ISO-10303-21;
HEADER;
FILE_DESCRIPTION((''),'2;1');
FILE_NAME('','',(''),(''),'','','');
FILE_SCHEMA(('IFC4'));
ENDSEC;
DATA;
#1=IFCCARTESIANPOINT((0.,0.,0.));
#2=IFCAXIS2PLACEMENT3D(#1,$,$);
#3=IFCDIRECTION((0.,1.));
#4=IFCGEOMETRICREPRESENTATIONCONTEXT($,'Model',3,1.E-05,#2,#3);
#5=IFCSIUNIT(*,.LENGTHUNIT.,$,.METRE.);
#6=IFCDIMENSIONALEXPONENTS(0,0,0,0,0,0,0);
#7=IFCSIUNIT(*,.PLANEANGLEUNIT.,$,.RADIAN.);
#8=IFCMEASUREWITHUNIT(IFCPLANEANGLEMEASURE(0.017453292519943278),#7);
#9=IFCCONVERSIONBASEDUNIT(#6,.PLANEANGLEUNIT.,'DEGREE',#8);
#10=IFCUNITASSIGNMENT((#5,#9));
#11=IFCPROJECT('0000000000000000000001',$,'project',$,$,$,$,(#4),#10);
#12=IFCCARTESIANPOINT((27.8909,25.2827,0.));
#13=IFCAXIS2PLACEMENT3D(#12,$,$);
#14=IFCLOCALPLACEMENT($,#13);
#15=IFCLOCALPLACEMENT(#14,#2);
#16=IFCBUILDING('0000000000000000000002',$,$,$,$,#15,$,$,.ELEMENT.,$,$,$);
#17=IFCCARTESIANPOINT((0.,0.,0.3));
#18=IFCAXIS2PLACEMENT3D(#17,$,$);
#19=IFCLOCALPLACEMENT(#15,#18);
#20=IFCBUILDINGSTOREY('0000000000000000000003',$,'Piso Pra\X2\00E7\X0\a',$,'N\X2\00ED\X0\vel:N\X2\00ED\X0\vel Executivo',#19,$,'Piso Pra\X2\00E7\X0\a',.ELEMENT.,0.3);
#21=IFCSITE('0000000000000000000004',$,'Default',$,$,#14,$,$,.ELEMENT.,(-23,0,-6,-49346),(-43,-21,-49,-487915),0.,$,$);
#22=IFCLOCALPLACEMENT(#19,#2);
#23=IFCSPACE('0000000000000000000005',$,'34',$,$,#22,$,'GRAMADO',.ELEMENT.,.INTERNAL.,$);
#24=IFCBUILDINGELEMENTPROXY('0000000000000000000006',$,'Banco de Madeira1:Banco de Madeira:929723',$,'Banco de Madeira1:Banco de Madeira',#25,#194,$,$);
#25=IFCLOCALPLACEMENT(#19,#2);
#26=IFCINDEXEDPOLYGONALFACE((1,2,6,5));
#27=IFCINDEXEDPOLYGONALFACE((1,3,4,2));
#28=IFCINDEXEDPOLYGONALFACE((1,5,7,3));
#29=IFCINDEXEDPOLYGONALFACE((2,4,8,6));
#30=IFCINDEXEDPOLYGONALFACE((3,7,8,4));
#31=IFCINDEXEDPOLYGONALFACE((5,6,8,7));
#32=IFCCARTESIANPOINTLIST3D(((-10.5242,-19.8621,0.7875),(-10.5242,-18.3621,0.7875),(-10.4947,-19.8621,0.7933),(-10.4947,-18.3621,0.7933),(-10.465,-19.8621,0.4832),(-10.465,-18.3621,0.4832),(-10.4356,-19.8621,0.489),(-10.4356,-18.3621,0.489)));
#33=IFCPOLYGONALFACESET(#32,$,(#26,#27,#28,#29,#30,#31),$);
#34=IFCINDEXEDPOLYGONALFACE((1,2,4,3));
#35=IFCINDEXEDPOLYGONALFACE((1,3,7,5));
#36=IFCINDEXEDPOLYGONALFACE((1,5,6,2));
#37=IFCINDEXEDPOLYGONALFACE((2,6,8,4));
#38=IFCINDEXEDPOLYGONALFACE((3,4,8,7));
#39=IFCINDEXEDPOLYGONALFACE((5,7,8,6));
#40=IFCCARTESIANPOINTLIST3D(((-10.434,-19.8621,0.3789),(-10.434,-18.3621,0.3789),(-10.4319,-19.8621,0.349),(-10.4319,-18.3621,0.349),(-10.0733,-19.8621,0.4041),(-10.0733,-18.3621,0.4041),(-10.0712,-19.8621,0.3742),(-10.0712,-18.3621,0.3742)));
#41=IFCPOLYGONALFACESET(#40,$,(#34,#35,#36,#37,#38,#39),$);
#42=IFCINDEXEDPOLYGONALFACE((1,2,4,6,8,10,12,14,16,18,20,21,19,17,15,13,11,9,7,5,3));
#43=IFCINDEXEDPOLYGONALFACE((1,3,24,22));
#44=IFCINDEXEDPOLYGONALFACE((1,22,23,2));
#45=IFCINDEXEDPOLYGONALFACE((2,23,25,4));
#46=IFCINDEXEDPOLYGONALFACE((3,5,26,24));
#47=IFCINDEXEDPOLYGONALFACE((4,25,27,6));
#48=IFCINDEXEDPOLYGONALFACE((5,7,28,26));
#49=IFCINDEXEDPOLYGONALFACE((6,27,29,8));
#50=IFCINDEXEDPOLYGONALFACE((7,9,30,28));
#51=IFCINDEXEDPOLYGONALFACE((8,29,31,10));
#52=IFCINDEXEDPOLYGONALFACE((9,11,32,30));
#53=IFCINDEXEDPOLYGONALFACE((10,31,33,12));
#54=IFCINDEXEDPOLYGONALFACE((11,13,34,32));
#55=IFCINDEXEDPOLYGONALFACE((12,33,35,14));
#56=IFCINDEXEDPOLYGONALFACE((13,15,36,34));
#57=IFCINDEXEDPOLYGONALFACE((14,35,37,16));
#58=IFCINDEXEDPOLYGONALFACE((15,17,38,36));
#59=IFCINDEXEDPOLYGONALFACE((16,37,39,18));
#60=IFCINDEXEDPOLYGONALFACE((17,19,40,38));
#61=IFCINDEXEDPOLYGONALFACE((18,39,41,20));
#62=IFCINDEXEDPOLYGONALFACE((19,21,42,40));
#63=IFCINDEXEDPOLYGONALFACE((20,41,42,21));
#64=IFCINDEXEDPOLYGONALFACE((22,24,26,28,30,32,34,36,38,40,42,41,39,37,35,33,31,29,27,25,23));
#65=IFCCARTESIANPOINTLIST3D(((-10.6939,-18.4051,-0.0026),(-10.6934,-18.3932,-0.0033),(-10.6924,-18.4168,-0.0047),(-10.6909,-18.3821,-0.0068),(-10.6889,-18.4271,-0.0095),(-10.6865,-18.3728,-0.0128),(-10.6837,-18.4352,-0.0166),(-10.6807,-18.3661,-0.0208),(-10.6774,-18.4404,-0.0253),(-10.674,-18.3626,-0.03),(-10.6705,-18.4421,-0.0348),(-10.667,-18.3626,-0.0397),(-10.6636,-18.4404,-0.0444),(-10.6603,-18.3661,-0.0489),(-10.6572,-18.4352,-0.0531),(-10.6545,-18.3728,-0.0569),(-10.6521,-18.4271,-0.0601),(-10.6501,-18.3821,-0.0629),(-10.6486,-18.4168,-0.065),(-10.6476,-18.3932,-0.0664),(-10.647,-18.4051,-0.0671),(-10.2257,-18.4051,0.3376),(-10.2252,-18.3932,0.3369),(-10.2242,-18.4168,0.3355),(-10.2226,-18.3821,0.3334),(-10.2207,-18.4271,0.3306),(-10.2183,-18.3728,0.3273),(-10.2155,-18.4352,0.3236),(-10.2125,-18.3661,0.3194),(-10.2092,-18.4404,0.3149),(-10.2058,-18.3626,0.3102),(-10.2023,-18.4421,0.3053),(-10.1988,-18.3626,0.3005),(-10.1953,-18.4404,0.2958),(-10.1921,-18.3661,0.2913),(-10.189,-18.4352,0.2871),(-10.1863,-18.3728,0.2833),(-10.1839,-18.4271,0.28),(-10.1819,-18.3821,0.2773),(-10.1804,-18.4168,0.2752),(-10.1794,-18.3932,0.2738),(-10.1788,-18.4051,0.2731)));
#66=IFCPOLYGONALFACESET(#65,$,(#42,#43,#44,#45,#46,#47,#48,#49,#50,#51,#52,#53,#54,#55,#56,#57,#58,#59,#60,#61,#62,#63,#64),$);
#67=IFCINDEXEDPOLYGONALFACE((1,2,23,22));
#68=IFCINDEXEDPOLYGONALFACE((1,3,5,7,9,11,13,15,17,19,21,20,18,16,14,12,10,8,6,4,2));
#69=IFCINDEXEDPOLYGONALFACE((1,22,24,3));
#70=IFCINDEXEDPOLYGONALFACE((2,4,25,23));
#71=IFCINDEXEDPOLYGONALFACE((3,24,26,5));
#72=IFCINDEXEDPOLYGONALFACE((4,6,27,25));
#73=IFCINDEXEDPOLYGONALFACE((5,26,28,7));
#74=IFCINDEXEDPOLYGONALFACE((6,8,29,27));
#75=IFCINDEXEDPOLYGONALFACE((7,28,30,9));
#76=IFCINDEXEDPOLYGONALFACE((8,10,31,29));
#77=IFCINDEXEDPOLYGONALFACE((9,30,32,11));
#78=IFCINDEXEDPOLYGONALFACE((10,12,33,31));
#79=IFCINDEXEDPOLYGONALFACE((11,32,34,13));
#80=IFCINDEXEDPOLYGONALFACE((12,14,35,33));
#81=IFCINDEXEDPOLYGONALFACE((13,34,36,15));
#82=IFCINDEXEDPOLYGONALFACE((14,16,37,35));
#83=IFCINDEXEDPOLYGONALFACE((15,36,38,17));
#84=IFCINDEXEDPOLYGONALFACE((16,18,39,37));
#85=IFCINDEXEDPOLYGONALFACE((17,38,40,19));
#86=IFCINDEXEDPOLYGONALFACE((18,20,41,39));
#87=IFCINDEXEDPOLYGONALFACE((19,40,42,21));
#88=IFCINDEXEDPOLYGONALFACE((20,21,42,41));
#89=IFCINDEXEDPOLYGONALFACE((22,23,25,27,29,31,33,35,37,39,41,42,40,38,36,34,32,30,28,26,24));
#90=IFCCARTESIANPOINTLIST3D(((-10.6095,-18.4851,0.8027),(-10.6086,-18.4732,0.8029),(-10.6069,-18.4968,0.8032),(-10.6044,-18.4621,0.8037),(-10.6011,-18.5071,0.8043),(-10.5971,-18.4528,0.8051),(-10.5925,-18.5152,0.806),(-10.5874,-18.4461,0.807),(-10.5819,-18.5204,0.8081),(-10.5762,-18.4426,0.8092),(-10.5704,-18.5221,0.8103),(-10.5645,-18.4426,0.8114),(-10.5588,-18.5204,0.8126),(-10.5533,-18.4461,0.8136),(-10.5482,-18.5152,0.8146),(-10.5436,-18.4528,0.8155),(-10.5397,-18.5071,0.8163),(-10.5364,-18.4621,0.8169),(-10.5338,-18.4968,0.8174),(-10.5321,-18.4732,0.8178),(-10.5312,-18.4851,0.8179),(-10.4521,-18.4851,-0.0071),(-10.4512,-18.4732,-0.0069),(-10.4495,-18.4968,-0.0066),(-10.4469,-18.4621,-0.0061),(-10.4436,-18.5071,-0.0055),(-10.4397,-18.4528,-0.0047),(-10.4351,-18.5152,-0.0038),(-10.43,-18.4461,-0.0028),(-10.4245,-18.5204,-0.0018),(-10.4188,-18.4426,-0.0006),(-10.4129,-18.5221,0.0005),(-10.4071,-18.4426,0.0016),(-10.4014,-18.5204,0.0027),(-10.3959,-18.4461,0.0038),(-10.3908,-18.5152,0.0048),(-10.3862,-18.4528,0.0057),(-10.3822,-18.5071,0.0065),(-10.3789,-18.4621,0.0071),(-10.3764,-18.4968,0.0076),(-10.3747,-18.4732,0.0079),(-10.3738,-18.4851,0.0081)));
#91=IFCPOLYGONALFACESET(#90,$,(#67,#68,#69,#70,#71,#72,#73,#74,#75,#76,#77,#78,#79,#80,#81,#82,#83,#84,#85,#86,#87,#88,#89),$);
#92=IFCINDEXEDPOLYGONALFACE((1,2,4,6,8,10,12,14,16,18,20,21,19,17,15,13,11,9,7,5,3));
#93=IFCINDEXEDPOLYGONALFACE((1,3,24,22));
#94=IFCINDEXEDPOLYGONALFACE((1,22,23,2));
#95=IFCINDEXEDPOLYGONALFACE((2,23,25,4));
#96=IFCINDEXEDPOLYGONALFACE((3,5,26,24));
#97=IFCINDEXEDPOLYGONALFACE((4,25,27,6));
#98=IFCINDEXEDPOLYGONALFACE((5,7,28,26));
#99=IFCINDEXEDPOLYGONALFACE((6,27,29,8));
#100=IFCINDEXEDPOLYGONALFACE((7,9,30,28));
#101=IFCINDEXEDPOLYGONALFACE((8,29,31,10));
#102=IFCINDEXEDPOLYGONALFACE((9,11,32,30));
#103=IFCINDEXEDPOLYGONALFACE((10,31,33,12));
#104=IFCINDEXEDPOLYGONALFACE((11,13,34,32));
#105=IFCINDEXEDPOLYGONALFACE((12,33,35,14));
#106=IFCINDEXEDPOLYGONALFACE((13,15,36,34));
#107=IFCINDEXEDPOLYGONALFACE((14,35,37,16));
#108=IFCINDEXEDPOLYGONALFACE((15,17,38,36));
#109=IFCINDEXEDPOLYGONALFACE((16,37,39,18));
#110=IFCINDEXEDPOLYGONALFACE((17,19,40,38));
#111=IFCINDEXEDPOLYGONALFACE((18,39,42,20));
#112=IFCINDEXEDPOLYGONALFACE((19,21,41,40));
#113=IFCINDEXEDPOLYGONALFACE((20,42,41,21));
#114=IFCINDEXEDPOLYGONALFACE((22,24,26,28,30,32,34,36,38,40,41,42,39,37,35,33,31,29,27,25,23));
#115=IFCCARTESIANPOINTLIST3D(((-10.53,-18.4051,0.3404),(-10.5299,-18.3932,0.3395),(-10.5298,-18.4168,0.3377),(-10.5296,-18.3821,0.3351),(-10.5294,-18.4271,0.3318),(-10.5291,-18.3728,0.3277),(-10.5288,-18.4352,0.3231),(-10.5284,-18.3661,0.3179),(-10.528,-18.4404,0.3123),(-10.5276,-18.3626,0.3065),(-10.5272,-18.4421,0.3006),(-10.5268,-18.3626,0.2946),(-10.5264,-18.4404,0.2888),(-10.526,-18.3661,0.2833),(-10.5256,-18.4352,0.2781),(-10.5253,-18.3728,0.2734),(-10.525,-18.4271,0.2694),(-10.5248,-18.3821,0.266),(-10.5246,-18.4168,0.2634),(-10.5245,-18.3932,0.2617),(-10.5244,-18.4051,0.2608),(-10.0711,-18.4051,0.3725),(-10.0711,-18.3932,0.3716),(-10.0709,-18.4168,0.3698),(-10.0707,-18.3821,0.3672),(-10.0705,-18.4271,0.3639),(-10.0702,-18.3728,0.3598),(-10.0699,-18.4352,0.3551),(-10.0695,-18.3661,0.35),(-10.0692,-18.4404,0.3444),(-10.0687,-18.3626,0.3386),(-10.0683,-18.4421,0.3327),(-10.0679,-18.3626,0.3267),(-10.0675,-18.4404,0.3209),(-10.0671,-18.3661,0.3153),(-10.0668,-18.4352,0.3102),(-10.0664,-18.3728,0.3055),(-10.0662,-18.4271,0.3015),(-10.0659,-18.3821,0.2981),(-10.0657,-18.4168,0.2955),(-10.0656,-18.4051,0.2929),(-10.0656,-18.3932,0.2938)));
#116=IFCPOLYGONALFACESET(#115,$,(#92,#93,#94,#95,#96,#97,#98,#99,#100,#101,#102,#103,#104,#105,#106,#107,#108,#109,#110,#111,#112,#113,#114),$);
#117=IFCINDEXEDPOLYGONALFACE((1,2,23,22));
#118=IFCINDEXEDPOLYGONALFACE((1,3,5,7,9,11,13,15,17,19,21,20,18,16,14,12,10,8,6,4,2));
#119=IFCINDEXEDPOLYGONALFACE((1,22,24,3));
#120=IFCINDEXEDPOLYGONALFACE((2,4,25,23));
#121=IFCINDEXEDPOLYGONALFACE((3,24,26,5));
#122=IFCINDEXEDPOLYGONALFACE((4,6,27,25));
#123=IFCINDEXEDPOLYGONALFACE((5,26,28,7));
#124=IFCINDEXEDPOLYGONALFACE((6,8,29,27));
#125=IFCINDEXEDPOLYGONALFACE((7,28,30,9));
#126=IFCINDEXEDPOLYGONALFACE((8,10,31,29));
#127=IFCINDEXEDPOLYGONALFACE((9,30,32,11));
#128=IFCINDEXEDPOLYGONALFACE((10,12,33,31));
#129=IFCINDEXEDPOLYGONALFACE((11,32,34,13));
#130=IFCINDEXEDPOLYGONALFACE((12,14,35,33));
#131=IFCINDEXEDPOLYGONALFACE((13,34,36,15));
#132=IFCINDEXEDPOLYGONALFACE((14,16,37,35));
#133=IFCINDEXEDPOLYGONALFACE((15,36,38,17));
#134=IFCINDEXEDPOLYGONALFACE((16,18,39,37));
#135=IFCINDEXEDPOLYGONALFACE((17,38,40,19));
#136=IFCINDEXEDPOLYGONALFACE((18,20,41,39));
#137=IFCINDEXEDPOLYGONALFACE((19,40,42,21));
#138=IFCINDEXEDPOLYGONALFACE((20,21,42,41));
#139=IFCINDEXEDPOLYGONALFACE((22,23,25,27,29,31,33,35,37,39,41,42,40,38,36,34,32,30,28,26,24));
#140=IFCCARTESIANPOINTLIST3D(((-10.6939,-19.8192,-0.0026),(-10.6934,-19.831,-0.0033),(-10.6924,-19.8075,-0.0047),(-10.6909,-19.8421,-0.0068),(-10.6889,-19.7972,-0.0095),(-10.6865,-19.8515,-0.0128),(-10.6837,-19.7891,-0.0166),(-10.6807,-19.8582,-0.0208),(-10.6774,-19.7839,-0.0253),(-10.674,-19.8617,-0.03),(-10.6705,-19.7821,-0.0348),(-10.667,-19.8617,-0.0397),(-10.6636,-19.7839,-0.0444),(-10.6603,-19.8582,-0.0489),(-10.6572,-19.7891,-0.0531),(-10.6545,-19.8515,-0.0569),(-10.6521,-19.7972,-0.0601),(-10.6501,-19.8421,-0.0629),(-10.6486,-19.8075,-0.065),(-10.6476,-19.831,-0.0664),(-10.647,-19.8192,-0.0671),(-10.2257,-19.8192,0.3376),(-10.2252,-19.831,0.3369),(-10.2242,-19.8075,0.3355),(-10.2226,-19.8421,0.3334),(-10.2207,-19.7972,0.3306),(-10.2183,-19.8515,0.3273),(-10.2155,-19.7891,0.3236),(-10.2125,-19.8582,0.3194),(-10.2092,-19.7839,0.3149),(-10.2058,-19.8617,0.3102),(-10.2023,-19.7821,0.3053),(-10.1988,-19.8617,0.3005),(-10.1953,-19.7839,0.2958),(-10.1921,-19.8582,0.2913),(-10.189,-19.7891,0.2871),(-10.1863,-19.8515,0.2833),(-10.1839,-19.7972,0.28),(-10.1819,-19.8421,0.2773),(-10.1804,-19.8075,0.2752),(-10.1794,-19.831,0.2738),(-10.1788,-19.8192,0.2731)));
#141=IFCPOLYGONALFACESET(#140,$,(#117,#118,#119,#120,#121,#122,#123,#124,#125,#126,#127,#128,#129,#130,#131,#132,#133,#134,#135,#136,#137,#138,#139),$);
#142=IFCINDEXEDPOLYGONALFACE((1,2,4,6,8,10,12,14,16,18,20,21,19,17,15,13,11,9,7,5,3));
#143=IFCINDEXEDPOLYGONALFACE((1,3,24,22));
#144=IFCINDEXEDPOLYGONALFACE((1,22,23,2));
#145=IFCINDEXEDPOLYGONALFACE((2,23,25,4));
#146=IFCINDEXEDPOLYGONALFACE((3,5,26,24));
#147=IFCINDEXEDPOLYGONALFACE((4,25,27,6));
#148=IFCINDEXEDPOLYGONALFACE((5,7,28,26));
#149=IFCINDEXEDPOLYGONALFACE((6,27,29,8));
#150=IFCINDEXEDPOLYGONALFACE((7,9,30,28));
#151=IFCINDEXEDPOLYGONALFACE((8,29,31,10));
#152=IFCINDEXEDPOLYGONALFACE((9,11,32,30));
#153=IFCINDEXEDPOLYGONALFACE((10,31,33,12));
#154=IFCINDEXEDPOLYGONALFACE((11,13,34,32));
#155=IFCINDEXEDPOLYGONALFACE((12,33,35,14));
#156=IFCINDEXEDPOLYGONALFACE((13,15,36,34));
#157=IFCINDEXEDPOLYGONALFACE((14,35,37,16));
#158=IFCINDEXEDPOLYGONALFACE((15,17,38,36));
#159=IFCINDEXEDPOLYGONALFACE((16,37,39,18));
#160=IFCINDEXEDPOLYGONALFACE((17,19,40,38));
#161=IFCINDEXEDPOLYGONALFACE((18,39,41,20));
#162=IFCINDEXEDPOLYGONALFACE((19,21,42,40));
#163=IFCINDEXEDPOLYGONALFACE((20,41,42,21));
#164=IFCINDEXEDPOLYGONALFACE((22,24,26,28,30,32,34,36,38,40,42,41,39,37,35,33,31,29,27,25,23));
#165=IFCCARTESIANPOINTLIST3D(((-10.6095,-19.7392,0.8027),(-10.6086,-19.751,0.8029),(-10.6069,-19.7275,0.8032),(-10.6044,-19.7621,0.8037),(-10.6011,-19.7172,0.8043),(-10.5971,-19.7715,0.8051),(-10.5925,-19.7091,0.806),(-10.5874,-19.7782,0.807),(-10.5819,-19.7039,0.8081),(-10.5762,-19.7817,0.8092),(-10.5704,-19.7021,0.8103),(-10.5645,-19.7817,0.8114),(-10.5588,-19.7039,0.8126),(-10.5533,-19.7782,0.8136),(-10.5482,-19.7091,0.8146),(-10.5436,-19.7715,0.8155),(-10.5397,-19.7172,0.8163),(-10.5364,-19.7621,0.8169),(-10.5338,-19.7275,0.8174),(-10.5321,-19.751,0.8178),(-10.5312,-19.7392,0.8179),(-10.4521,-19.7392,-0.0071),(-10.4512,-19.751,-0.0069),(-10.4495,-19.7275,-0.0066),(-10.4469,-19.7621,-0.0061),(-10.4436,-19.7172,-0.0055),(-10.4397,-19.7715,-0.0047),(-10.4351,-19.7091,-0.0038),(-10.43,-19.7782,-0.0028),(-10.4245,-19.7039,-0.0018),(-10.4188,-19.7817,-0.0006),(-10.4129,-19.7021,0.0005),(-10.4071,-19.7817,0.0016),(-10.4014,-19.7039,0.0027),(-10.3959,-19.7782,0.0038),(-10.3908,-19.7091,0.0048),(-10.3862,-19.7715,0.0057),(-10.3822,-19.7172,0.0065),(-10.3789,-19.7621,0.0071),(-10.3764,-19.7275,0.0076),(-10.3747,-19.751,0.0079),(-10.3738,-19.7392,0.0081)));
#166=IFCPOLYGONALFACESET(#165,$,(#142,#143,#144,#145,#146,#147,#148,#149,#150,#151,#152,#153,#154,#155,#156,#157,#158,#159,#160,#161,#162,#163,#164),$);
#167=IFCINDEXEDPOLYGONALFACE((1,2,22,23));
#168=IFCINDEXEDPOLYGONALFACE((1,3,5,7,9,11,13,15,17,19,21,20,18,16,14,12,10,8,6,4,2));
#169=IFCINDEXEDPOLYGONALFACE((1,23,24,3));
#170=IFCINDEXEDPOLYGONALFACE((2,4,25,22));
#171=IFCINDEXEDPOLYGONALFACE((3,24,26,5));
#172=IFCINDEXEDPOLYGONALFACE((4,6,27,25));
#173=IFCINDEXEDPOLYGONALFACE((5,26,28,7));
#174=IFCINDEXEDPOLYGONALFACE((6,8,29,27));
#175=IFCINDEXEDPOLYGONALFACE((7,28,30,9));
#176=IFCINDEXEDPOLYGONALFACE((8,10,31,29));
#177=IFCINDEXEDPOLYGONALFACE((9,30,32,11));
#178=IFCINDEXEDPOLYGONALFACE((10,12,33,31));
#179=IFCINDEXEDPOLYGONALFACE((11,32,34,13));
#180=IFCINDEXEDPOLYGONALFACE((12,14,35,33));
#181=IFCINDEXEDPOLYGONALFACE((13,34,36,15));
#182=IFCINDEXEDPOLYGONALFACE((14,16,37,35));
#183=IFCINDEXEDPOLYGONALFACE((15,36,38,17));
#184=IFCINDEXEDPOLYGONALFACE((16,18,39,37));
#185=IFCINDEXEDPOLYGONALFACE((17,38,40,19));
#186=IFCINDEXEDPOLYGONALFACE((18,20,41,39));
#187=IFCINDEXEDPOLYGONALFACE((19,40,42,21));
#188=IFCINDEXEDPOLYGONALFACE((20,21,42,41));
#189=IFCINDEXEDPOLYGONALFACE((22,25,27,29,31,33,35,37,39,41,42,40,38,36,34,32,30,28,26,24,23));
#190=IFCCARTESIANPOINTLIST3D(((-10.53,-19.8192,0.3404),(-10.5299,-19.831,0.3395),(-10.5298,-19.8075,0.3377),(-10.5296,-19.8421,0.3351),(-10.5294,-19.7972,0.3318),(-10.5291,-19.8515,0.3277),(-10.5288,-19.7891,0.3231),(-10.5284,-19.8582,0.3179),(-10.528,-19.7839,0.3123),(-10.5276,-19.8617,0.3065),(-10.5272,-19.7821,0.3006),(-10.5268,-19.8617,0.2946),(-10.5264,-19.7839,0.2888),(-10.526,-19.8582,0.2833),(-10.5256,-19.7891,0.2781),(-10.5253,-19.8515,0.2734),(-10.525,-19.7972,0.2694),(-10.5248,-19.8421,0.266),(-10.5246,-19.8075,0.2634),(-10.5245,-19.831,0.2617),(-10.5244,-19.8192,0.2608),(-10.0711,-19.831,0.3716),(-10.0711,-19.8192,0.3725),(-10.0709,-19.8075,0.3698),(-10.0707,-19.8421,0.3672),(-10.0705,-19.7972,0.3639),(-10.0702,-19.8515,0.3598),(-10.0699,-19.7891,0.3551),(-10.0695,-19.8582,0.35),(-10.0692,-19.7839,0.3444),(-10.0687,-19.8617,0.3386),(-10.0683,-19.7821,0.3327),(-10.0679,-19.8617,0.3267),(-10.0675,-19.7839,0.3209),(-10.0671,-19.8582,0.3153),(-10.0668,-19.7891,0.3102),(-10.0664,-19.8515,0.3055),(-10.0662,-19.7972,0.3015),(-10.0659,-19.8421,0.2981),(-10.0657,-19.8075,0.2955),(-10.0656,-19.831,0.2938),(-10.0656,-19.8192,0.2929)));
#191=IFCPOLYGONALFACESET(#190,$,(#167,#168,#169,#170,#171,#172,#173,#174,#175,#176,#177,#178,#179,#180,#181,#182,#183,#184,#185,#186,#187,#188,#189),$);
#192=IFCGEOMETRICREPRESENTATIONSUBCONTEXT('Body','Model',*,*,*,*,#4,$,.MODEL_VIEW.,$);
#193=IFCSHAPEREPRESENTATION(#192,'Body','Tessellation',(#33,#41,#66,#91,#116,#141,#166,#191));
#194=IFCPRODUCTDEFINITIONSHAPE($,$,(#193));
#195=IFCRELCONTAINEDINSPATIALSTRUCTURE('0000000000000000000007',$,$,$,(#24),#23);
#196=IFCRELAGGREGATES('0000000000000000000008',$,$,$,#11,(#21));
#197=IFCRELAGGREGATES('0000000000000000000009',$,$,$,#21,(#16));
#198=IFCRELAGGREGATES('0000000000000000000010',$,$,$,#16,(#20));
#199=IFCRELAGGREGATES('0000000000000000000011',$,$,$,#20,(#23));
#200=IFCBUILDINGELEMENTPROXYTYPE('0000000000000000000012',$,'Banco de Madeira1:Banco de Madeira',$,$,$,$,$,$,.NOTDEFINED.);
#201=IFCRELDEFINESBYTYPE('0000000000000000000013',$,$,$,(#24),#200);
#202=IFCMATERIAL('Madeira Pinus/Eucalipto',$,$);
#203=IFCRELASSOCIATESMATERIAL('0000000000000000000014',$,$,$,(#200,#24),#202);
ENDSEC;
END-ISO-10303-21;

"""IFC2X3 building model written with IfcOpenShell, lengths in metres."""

from ifc_helpers import new_model, entity, si_unit, converted_unit, direction, frame, frame_2d, origin, place, context, subcontext, project, spatial, rectangle, circle, extrude, source, transform, mapped, material, type_object, type_shapes, element, save


model = new_model("IFC2X3")

# Units and contexts
model_context = context("Model", 3, precision=1e-05, world=origin(), true_north=direction((0.0, 1.0)))
body_context = subcontext(model_context, "Body", "Model", "MODEL_VIEW")
ifc_project = project(units=[si_unit("LENGTHUNIT", "METRE"), converted_unit("PLANEANGLEUNIT", "DEGREE", entity("IfcPlaneAngleMeasure", 0.017453292519943278), si_unit("PLANEANGLEUNIT", "RADIAN"), dimensions=[0, 0, 0, 0, 0, 0, 0])], contexts=[model_context])

# Site, building, storey
site_placement = place(None, frame((27.8909, 25.2827, 0.0)))
site = spatial("IfcSite", under=ifc_project, at=site_placement, Name="Default", CompositionType="ELEMENT", RefLatitude=(-23, 0, -6, -49346), RefLongitude=(-43, -21, -49, -487915), RefElevation=0.0)
building_placement = place(site_placement, origin())
building = spatial("IfcBuilding", under=site, at=building_placement, CompositionType="ELEMENT")
storey_placement = place(building_placement, frame((0.0, 0.0, 0.3)))
storey = spatial("IfcBuildingStorey", under=building, at=storey_placement, Name="Piso Praça", ObjectType="Nível:Nível Executivo", LongName="Piso Praça", CompositionType="ELEMENT", Elevation=0.3)

# Shared definitions
ifc_material_1 = material(Name="Madeira Pinus/Eucalipto")

# Shared definitions
space_1_placement = place(storey_placement, origin())
space_1 = spatial("IfcSpace", under=storey, at=space_1_placement, Name="34", LongName="GRAMADO", CompositionType="ELEMENT", InteriorOrExteriorSpace="INTERNAL")

# Building element proxy
building_element_proxy_type_1 = type_object("IfcBuildingElementProxyType", Name="Banco de Madeira1:Banco de Madeira", PredefinedType="NOTDEFINED", material=ifc_material_1)
shared_shape_1 = source(origin(), body_context, "Body", "SweptSolid", [
    extrude(rectangle(XDim=0.31, YDim=0.03, at=frame_2d((0.0, 0.0), x_axis=(1.0, 0.0))), frame((-0.75, 0.1439, 0.6383), z_axis=(1.0, 0.0, 0.0), x_axis=(0.0, 0.190809, 0.981627)), (0.0, 0.0, 1.0), 1.5),
    extrude(rectangle(XDim=0.03, YDim=0.3616, at=frame_2d((0.0, 0.0), x_axis=(0.0, 1.0))), frame((-0.75, -0.0833, 0.3765), z_axis=(1.0, 0.0, 0.0), x_axis=(0.0, 0.997564, -0.069756)), (0.0, 0.0, 1.0), 1.5),
    extrude(circle(Radius=0.04, at=frame_2d((0.0, 0.0), x_axis=(1.0, 0.0))), frame((0.71, 0.3345, -0.0348), z_axis=(0.0, -0.809017, 0.587785), x_axis=(-1.0, 0.0, 0.0)), (0.0, 0.0, 1.0), 0.5788),
    extrude(circle(Radius=0.04, at=frame_2d((0.0, 0.0), x_axis=(1.0, 0.0))), frame((0.63, 0.077, 0.0005), z_axis=(0.0, 0.190809, 0.981627), x_axis=(-1.0, 0.0, 0.0)), (0.0, 0.0, 1.0), 0.825),
    extrude(circle(Radius=0.04, at=frame_2d((0.0, 0.0), x_axis=(1.0, 0.0))), frame((0.71, -0.2676, 0.3327), z_axis=(0.0, 0.997564, -0.069756), x_axis=(-1.0, 0.0, 0.0)), (0.0, 0.0, 1.0), 0.46),
    extrude(circle(Radius=0.04, at=frame_2d((0.0, 0.0), x_axis=(1.0, 0.0))), frame((-0.71, 0.3345, -0.0348), z_axis=(0.0, -0.809017, 0.587785), x_axis=(1.0, 0.0, 0.0)), (0.0, 0.0, 1.0), 0.5788),
    extrude(circle(Radius=0.04, at=frame_2d((0.0, 0.0), x_axis=(1.0, 0.0))), frame((-0.63, 0.077, 0.0005), z_axis=(0.0, 0.190809, 0.981627), x_axis=(1.0, 0.0, 0.0)), (0.0, 0.0, 1.0), 0.825),
    extrude(circle(Radius=0.04, at=frame_2d((0.0, 0.0), x_axis=(1.0, 0.0))), frame((-0.71, -0.2676, 0.3327), z_axis=(0.0, 0.997564, -0.069756), x_axis=(1.0, 0.0, 0.0)), (0.0, 0.0, 1.0), 0.46),
])
type_shapes(building_element_proxy_type_1, [shared_shape_1])
proxy_1_placement = place(space_1_placement, frame((-10.3359, -19.1121, 0.0), z_axis=(0.0, 0.0, 1.0), x_axis=(0.0, 1.0, 0.0)))
element("IfcBuildingElementProxy", 1, at=proxy_1_placement, inside=space_1, type_object=building_element_proxy_type_1, material=ifc_material_1, Name="Banco de Madeira1:Banco de Madeira:929723", ObjectType="Banco de Madeira1:Banco de Madeira", context=body_context, shape_type="MappedRepresentation", body=[
    mapped(shared_shape_1, transform((0.0, 0.0, 0.0), scale=1.0)),
])

save(model, "model.ifc")
